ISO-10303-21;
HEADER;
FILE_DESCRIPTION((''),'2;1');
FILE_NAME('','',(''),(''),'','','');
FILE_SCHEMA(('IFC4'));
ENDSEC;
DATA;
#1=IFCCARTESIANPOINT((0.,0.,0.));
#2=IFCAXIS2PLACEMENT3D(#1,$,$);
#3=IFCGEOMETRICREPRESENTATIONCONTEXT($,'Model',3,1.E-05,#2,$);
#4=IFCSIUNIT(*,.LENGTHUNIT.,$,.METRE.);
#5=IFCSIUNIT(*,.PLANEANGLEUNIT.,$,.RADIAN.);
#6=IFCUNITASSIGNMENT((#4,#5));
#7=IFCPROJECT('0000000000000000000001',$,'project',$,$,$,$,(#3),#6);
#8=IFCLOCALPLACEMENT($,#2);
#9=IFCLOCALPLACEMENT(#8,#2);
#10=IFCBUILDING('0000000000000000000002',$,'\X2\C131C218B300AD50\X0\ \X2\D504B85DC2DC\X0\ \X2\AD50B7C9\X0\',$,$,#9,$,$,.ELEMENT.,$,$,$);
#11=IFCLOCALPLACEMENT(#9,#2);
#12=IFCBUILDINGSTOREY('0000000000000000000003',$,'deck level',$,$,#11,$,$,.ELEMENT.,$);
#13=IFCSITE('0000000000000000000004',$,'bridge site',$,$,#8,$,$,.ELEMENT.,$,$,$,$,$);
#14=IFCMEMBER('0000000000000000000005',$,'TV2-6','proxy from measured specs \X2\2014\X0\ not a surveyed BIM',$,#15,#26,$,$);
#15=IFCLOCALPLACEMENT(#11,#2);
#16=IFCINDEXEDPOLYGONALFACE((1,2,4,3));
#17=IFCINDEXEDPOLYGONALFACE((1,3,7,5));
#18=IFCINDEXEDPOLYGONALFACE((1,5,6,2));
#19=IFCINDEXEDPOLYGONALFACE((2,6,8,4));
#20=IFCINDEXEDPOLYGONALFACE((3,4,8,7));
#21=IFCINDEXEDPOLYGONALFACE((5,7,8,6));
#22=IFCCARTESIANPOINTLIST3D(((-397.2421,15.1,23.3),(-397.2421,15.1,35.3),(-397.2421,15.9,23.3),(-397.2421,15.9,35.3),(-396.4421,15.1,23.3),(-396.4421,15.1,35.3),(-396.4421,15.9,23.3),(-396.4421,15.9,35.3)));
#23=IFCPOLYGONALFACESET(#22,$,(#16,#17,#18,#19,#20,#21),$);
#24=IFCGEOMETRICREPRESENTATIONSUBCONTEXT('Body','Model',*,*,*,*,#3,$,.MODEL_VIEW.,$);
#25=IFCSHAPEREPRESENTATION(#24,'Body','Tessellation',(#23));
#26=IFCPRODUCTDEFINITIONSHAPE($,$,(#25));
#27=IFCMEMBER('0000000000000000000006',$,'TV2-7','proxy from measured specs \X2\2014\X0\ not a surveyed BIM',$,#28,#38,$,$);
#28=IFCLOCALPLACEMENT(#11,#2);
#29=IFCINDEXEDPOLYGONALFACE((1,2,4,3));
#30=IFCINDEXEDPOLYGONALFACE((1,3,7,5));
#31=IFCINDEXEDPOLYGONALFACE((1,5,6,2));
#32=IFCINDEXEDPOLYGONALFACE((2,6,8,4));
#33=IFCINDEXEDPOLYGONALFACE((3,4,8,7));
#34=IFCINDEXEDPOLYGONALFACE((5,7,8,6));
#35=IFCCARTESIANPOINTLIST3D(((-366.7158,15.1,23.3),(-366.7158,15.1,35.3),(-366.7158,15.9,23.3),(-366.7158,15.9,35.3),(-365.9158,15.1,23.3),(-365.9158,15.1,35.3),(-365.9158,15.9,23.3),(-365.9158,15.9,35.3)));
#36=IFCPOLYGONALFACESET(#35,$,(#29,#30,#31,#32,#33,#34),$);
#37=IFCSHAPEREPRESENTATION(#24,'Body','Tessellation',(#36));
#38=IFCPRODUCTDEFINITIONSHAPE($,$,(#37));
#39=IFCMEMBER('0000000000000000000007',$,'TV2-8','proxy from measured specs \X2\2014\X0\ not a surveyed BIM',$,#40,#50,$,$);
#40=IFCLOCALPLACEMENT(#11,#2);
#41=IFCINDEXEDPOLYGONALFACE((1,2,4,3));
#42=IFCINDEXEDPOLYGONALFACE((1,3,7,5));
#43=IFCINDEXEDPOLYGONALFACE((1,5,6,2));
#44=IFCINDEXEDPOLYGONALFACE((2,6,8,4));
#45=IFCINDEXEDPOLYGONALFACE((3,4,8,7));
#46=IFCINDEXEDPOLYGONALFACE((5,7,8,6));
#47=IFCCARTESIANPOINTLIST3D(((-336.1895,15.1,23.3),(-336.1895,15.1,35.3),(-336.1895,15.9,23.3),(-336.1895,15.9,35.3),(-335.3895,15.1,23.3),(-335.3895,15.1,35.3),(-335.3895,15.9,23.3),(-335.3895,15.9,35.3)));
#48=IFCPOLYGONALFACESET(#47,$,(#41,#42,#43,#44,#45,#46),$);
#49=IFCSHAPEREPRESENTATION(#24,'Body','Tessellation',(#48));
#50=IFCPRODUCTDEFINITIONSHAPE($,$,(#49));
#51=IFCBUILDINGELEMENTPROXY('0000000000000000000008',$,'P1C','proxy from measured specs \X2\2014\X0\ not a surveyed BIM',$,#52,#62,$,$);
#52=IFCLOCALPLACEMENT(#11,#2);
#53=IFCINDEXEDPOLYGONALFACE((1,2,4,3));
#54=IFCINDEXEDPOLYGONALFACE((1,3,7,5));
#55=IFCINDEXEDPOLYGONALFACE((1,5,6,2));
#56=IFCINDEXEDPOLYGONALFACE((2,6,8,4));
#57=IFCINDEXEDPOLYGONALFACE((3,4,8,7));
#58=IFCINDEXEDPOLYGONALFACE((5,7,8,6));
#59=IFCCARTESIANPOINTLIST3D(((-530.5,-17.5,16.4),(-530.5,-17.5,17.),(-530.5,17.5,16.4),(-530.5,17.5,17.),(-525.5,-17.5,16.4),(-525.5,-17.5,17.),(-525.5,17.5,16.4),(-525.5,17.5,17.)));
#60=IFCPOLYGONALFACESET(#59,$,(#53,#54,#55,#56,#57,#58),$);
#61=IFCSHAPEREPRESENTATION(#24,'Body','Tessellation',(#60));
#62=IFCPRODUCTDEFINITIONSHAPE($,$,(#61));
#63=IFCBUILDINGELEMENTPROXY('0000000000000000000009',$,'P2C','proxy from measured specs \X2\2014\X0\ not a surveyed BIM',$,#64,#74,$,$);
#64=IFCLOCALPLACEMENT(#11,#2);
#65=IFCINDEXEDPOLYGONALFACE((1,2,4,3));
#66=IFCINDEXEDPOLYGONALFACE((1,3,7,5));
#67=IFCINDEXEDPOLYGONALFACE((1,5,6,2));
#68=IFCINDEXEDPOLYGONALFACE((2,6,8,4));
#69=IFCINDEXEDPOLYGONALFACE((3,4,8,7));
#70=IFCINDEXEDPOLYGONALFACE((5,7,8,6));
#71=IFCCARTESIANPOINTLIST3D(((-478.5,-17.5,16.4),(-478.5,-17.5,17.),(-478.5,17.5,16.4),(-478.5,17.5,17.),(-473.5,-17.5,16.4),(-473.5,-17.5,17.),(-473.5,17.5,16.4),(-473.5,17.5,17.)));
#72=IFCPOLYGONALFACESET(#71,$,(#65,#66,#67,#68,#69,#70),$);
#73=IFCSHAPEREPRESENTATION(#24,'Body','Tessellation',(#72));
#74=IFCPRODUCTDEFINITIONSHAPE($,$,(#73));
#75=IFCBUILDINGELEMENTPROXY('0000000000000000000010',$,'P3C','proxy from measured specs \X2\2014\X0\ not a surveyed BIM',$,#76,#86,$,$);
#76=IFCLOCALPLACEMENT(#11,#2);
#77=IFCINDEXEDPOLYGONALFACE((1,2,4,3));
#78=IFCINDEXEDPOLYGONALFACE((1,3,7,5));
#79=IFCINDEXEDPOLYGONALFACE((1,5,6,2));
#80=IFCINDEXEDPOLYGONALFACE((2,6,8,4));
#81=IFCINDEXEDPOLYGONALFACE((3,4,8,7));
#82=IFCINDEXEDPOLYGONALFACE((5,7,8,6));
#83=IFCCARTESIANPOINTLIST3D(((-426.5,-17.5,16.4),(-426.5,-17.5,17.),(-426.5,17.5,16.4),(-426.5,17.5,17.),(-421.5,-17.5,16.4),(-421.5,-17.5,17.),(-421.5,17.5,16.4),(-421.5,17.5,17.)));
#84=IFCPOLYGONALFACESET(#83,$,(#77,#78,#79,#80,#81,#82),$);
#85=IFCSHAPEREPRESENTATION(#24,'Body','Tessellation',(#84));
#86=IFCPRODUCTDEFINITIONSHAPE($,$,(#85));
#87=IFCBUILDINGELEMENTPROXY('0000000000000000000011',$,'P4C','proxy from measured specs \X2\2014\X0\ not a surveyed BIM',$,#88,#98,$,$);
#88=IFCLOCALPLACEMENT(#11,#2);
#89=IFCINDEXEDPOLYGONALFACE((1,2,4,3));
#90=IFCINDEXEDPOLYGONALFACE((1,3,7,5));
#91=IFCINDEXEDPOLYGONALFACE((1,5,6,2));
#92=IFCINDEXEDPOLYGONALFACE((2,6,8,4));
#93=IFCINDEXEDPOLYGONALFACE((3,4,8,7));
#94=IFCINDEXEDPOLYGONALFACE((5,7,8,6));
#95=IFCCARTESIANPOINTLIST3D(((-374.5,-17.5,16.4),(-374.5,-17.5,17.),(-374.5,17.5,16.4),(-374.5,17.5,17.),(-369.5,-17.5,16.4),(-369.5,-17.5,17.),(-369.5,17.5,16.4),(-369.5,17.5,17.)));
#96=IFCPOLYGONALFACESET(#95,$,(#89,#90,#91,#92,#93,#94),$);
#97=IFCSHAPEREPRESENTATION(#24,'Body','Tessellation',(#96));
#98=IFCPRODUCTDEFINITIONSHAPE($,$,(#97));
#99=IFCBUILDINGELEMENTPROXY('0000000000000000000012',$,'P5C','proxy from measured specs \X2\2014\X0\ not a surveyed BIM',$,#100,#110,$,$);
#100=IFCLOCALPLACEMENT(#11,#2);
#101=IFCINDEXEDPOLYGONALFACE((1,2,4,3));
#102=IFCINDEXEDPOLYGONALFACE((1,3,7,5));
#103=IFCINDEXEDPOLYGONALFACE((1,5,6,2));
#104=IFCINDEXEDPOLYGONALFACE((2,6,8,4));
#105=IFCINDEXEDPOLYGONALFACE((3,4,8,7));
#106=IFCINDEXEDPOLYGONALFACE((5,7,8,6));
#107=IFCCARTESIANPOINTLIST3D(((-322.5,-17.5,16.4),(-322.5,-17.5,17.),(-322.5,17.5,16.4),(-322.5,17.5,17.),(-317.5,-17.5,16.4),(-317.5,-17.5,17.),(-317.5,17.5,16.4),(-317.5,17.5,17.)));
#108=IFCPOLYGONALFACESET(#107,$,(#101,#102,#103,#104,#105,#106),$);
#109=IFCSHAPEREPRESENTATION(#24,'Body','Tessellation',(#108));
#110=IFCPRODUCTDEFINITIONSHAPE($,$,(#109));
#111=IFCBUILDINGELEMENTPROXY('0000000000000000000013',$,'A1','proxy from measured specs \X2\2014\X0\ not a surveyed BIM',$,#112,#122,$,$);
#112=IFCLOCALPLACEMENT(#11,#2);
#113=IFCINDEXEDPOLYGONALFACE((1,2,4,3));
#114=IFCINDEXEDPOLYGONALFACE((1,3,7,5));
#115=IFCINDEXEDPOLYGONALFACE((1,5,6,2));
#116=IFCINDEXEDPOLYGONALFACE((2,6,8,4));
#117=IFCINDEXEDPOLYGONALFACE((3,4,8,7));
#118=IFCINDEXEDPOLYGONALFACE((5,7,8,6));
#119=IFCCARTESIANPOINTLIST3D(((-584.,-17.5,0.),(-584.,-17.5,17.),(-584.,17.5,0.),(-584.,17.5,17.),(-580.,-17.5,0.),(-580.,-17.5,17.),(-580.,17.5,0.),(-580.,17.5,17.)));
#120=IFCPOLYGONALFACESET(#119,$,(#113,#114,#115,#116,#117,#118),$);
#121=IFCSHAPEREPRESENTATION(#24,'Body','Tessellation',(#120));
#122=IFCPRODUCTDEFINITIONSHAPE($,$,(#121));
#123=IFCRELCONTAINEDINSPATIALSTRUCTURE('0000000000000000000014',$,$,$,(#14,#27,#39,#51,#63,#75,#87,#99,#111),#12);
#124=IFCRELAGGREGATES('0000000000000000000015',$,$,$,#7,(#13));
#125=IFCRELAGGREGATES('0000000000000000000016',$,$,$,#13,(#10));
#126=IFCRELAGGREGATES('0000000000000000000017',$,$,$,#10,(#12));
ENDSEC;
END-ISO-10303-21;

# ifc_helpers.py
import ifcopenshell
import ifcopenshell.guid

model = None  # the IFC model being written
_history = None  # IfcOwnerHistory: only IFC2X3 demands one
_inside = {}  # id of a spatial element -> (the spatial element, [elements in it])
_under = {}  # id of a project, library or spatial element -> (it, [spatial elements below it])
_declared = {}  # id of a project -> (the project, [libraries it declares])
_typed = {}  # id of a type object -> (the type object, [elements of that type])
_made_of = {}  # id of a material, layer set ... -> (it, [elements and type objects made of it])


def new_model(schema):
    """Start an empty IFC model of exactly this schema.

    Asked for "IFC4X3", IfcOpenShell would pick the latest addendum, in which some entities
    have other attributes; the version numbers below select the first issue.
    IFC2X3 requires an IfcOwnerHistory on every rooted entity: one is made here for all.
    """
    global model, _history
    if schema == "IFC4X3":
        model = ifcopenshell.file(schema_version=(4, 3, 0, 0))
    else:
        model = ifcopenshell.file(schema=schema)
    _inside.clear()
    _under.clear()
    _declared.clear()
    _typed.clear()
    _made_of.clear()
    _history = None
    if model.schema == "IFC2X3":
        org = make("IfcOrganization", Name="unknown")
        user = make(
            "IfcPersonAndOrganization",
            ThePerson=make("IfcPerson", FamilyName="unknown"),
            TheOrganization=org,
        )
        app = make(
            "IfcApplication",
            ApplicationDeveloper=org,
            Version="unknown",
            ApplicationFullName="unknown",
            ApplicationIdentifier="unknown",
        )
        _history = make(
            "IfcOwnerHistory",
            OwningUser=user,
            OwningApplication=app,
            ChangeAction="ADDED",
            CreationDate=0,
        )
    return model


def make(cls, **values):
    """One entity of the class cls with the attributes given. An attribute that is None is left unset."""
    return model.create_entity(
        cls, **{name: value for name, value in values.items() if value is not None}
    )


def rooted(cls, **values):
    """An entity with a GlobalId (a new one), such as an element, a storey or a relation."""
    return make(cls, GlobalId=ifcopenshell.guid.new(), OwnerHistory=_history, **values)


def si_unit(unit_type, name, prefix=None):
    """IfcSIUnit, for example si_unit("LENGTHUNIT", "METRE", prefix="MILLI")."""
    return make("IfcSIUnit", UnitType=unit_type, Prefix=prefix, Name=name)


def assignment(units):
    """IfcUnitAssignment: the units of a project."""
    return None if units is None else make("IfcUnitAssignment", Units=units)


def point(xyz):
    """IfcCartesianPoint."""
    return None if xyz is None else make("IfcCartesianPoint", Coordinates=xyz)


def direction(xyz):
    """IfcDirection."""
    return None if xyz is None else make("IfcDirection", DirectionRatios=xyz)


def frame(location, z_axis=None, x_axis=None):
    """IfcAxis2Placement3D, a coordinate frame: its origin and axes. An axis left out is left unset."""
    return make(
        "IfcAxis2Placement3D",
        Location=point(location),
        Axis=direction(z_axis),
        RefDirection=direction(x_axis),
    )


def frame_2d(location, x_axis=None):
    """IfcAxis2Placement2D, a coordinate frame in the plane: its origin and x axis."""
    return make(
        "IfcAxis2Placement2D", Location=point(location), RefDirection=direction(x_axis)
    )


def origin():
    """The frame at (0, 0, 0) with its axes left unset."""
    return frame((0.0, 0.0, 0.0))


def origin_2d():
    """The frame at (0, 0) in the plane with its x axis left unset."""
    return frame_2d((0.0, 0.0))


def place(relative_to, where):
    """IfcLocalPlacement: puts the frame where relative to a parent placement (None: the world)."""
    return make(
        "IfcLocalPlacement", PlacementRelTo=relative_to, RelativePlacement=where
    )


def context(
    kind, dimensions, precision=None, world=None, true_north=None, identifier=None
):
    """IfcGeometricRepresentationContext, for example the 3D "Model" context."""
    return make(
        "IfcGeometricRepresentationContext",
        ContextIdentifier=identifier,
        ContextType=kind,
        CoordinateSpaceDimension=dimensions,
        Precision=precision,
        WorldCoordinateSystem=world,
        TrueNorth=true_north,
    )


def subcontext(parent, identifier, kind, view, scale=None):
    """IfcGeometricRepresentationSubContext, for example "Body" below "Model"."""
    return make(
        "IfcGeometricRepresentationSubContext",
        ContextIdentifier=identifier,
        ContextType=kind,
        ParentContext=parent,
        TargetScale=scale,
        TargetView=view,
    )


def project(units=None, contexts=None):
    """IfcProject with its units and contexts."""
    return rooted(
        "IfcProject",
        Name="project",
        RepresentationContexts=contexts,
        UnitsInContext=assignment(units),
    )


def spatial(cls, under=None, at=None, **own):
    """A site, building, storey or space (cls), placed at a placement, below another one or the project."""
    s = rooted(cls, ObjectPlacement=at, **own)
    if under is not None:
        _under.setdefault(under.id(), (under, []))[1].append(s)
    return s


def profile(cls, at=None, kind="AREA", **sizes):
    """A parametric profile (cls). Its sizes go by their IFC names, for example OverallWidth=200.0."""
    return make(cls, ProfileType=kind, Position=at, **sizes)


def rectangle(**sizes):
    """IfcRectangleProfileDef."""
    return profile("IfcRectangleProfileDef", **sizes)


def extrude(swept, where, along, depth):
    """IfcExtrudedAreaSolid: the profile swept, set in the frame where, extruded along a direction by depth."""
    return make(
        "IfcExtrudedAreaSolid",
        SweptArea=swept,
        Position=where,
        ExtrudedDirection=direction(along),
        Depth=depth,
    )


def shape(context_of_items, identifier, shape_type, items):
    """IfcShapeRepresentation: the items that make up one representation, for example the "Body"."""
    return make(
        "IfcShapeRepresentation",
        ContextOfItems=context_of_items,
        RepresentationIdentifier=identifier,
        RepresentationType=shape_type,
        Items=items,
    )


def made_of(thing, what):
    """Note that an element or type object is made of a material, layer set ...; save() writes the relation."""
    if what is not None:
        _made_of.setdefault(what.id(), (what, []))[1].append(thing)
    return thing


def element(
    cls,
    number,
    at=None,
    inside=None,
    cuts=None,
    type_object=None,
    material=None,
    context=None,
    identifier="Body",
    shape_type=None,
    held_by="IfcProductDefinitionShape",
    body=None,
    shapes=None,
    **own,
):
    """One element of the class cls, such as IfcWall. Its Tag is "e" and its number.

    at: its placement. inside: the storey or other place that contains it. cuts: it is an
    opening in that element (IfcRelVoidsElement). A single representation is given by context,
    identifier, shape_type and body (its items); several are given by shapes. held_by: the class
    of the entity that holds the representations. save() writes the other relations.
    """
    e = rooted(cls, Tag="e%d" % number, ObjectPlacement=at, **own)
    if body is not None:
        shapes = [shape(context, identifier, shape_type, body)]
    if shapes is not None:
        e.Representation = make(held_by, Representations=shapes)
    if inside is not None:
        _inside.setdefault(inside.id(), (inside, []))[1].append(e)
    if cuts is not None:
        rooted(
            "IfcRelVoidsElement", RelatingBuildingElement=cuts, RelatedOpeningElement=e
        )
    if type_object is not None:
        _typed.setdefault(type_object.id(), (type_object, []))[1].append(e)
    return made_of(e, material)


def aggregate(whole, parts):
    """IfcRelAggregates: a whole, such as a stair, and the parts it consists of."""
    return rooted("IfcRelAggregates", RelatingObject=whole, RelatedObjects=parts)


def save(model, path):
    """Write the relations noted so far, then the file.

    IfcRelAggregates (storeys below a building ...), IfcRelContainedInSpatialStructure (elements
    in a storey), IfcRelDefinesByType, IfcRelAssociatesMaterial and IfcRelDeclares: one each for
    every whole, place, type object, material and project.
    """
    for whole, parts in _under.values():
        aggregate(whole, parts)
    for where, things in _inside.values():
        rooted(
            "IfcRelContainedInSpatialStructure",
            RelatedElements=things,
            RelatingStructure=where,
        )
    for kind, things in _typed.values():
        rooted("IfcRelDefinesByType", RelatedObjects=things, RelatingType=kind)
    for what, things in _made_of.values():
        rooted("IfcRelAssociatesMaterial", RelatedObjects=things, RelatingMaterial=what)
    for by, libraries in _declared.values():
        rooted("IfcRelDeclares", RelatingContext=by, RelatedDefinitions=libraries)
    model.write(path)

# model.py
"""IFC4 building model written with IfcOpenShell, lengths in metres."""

from ifc_helpers import new_model, si_unit, frame, origin, origin_2d, place, context, subcontext, project, spatial, rectangle, extrude, element, save


model = new_model("IFC4")

# Units and contexts
model_context = context("Model", 3, precision=1e-05, world=origin())
body_context = subcontext(model_context, "Body", "Model", "MODEL_VIEW")
ifc_project = project(units=[si_unit("LENGTHUNIT", "METRE"), si_unit("PLANEANGLEUNIT", "RADIAN")], contexts=[model_context])

# Site, building, storey
site_placement = place(None, origin())
site = spatial("IfcSite", under=ifc_project, at=site_placement, Name="bridge site", CompositionType="ELEMENT")
building_placement = place(site_placement, origin())
building = spatial("IfcBuilding", under=site, at=building_placement, Name="성수대교 프록시 교량", CompositionType="ELEMENT")
storey_placement = place(building_placement, origin())
storey = spatial("IfcBuildingStorey", under=building, at=storey_placement, Name="deck level", CompositionType="ELEMENT")

# Members
for number, where, name in (
    (1, (-396.8421, 15.5, 23.3), "TV2-6"),
    (2, (-366.3158, 15.5, 23.3), "TV2-7"),
    (3, (-335.7895, 15.5, 23.3), "TV2-8"),
):
    element("IfcMember", number, at=place(storey_placement, frame(where)), inside=storey, Name=name, Description="proxy from measured specs — not a surveyed BIM", context=body_context, shape_type="SweptSolid", body=[
        extrude(rectangle(XDim=0.8, YDim=0.8, at=origin_2d()), origin(), (0.0, 0.0, 1.0), 12.0),
    ])

# Building element proxies
for number, where, name in (
    (4, (-528.0, 0.0, 16.4), "P1C"),
    (5, (-476.0, 0.0, 16.4), "P2C"),
    (6, (-424.0, 0.0, 16.4), "P3C"),
    (7, (-372.0, 0.0, 16.4), "P4C"),
    (8, (-320.0, 0.0, 16.4), "P5C"),
):
    element("IfcBuildingElementProxy", number, at=place(storey_placement, frame(where)), inside=storey, Name=name, Description="proxy from measured specs — not a surveyed BIM", context=body_context, shape_type="SweptSolid", body=[
        extrude(rectangle(XDim=5.0, YDim=35.0, at=origin_2d()), origin(), (0.0, 0.0, 1.0), 0.6),
    ])
proxy_placement = place(storey_placement, frame((-582.0, 0.0, 0.0)))
element("IfcBuildingElementProxy", 9, at=proxy_placement, inside=storey, Name="A1", Description="proxy from measured specs — not a surveyed BIM", context=body_context, shape_type="SweptSolid", body=[
    extrude(rectangle(XDim=4.0, YDim=35.0, at=origin_2d()), origin(), (0.0, 0.0, 1.0), 17.0),
])

save(model, "model.ifc")
